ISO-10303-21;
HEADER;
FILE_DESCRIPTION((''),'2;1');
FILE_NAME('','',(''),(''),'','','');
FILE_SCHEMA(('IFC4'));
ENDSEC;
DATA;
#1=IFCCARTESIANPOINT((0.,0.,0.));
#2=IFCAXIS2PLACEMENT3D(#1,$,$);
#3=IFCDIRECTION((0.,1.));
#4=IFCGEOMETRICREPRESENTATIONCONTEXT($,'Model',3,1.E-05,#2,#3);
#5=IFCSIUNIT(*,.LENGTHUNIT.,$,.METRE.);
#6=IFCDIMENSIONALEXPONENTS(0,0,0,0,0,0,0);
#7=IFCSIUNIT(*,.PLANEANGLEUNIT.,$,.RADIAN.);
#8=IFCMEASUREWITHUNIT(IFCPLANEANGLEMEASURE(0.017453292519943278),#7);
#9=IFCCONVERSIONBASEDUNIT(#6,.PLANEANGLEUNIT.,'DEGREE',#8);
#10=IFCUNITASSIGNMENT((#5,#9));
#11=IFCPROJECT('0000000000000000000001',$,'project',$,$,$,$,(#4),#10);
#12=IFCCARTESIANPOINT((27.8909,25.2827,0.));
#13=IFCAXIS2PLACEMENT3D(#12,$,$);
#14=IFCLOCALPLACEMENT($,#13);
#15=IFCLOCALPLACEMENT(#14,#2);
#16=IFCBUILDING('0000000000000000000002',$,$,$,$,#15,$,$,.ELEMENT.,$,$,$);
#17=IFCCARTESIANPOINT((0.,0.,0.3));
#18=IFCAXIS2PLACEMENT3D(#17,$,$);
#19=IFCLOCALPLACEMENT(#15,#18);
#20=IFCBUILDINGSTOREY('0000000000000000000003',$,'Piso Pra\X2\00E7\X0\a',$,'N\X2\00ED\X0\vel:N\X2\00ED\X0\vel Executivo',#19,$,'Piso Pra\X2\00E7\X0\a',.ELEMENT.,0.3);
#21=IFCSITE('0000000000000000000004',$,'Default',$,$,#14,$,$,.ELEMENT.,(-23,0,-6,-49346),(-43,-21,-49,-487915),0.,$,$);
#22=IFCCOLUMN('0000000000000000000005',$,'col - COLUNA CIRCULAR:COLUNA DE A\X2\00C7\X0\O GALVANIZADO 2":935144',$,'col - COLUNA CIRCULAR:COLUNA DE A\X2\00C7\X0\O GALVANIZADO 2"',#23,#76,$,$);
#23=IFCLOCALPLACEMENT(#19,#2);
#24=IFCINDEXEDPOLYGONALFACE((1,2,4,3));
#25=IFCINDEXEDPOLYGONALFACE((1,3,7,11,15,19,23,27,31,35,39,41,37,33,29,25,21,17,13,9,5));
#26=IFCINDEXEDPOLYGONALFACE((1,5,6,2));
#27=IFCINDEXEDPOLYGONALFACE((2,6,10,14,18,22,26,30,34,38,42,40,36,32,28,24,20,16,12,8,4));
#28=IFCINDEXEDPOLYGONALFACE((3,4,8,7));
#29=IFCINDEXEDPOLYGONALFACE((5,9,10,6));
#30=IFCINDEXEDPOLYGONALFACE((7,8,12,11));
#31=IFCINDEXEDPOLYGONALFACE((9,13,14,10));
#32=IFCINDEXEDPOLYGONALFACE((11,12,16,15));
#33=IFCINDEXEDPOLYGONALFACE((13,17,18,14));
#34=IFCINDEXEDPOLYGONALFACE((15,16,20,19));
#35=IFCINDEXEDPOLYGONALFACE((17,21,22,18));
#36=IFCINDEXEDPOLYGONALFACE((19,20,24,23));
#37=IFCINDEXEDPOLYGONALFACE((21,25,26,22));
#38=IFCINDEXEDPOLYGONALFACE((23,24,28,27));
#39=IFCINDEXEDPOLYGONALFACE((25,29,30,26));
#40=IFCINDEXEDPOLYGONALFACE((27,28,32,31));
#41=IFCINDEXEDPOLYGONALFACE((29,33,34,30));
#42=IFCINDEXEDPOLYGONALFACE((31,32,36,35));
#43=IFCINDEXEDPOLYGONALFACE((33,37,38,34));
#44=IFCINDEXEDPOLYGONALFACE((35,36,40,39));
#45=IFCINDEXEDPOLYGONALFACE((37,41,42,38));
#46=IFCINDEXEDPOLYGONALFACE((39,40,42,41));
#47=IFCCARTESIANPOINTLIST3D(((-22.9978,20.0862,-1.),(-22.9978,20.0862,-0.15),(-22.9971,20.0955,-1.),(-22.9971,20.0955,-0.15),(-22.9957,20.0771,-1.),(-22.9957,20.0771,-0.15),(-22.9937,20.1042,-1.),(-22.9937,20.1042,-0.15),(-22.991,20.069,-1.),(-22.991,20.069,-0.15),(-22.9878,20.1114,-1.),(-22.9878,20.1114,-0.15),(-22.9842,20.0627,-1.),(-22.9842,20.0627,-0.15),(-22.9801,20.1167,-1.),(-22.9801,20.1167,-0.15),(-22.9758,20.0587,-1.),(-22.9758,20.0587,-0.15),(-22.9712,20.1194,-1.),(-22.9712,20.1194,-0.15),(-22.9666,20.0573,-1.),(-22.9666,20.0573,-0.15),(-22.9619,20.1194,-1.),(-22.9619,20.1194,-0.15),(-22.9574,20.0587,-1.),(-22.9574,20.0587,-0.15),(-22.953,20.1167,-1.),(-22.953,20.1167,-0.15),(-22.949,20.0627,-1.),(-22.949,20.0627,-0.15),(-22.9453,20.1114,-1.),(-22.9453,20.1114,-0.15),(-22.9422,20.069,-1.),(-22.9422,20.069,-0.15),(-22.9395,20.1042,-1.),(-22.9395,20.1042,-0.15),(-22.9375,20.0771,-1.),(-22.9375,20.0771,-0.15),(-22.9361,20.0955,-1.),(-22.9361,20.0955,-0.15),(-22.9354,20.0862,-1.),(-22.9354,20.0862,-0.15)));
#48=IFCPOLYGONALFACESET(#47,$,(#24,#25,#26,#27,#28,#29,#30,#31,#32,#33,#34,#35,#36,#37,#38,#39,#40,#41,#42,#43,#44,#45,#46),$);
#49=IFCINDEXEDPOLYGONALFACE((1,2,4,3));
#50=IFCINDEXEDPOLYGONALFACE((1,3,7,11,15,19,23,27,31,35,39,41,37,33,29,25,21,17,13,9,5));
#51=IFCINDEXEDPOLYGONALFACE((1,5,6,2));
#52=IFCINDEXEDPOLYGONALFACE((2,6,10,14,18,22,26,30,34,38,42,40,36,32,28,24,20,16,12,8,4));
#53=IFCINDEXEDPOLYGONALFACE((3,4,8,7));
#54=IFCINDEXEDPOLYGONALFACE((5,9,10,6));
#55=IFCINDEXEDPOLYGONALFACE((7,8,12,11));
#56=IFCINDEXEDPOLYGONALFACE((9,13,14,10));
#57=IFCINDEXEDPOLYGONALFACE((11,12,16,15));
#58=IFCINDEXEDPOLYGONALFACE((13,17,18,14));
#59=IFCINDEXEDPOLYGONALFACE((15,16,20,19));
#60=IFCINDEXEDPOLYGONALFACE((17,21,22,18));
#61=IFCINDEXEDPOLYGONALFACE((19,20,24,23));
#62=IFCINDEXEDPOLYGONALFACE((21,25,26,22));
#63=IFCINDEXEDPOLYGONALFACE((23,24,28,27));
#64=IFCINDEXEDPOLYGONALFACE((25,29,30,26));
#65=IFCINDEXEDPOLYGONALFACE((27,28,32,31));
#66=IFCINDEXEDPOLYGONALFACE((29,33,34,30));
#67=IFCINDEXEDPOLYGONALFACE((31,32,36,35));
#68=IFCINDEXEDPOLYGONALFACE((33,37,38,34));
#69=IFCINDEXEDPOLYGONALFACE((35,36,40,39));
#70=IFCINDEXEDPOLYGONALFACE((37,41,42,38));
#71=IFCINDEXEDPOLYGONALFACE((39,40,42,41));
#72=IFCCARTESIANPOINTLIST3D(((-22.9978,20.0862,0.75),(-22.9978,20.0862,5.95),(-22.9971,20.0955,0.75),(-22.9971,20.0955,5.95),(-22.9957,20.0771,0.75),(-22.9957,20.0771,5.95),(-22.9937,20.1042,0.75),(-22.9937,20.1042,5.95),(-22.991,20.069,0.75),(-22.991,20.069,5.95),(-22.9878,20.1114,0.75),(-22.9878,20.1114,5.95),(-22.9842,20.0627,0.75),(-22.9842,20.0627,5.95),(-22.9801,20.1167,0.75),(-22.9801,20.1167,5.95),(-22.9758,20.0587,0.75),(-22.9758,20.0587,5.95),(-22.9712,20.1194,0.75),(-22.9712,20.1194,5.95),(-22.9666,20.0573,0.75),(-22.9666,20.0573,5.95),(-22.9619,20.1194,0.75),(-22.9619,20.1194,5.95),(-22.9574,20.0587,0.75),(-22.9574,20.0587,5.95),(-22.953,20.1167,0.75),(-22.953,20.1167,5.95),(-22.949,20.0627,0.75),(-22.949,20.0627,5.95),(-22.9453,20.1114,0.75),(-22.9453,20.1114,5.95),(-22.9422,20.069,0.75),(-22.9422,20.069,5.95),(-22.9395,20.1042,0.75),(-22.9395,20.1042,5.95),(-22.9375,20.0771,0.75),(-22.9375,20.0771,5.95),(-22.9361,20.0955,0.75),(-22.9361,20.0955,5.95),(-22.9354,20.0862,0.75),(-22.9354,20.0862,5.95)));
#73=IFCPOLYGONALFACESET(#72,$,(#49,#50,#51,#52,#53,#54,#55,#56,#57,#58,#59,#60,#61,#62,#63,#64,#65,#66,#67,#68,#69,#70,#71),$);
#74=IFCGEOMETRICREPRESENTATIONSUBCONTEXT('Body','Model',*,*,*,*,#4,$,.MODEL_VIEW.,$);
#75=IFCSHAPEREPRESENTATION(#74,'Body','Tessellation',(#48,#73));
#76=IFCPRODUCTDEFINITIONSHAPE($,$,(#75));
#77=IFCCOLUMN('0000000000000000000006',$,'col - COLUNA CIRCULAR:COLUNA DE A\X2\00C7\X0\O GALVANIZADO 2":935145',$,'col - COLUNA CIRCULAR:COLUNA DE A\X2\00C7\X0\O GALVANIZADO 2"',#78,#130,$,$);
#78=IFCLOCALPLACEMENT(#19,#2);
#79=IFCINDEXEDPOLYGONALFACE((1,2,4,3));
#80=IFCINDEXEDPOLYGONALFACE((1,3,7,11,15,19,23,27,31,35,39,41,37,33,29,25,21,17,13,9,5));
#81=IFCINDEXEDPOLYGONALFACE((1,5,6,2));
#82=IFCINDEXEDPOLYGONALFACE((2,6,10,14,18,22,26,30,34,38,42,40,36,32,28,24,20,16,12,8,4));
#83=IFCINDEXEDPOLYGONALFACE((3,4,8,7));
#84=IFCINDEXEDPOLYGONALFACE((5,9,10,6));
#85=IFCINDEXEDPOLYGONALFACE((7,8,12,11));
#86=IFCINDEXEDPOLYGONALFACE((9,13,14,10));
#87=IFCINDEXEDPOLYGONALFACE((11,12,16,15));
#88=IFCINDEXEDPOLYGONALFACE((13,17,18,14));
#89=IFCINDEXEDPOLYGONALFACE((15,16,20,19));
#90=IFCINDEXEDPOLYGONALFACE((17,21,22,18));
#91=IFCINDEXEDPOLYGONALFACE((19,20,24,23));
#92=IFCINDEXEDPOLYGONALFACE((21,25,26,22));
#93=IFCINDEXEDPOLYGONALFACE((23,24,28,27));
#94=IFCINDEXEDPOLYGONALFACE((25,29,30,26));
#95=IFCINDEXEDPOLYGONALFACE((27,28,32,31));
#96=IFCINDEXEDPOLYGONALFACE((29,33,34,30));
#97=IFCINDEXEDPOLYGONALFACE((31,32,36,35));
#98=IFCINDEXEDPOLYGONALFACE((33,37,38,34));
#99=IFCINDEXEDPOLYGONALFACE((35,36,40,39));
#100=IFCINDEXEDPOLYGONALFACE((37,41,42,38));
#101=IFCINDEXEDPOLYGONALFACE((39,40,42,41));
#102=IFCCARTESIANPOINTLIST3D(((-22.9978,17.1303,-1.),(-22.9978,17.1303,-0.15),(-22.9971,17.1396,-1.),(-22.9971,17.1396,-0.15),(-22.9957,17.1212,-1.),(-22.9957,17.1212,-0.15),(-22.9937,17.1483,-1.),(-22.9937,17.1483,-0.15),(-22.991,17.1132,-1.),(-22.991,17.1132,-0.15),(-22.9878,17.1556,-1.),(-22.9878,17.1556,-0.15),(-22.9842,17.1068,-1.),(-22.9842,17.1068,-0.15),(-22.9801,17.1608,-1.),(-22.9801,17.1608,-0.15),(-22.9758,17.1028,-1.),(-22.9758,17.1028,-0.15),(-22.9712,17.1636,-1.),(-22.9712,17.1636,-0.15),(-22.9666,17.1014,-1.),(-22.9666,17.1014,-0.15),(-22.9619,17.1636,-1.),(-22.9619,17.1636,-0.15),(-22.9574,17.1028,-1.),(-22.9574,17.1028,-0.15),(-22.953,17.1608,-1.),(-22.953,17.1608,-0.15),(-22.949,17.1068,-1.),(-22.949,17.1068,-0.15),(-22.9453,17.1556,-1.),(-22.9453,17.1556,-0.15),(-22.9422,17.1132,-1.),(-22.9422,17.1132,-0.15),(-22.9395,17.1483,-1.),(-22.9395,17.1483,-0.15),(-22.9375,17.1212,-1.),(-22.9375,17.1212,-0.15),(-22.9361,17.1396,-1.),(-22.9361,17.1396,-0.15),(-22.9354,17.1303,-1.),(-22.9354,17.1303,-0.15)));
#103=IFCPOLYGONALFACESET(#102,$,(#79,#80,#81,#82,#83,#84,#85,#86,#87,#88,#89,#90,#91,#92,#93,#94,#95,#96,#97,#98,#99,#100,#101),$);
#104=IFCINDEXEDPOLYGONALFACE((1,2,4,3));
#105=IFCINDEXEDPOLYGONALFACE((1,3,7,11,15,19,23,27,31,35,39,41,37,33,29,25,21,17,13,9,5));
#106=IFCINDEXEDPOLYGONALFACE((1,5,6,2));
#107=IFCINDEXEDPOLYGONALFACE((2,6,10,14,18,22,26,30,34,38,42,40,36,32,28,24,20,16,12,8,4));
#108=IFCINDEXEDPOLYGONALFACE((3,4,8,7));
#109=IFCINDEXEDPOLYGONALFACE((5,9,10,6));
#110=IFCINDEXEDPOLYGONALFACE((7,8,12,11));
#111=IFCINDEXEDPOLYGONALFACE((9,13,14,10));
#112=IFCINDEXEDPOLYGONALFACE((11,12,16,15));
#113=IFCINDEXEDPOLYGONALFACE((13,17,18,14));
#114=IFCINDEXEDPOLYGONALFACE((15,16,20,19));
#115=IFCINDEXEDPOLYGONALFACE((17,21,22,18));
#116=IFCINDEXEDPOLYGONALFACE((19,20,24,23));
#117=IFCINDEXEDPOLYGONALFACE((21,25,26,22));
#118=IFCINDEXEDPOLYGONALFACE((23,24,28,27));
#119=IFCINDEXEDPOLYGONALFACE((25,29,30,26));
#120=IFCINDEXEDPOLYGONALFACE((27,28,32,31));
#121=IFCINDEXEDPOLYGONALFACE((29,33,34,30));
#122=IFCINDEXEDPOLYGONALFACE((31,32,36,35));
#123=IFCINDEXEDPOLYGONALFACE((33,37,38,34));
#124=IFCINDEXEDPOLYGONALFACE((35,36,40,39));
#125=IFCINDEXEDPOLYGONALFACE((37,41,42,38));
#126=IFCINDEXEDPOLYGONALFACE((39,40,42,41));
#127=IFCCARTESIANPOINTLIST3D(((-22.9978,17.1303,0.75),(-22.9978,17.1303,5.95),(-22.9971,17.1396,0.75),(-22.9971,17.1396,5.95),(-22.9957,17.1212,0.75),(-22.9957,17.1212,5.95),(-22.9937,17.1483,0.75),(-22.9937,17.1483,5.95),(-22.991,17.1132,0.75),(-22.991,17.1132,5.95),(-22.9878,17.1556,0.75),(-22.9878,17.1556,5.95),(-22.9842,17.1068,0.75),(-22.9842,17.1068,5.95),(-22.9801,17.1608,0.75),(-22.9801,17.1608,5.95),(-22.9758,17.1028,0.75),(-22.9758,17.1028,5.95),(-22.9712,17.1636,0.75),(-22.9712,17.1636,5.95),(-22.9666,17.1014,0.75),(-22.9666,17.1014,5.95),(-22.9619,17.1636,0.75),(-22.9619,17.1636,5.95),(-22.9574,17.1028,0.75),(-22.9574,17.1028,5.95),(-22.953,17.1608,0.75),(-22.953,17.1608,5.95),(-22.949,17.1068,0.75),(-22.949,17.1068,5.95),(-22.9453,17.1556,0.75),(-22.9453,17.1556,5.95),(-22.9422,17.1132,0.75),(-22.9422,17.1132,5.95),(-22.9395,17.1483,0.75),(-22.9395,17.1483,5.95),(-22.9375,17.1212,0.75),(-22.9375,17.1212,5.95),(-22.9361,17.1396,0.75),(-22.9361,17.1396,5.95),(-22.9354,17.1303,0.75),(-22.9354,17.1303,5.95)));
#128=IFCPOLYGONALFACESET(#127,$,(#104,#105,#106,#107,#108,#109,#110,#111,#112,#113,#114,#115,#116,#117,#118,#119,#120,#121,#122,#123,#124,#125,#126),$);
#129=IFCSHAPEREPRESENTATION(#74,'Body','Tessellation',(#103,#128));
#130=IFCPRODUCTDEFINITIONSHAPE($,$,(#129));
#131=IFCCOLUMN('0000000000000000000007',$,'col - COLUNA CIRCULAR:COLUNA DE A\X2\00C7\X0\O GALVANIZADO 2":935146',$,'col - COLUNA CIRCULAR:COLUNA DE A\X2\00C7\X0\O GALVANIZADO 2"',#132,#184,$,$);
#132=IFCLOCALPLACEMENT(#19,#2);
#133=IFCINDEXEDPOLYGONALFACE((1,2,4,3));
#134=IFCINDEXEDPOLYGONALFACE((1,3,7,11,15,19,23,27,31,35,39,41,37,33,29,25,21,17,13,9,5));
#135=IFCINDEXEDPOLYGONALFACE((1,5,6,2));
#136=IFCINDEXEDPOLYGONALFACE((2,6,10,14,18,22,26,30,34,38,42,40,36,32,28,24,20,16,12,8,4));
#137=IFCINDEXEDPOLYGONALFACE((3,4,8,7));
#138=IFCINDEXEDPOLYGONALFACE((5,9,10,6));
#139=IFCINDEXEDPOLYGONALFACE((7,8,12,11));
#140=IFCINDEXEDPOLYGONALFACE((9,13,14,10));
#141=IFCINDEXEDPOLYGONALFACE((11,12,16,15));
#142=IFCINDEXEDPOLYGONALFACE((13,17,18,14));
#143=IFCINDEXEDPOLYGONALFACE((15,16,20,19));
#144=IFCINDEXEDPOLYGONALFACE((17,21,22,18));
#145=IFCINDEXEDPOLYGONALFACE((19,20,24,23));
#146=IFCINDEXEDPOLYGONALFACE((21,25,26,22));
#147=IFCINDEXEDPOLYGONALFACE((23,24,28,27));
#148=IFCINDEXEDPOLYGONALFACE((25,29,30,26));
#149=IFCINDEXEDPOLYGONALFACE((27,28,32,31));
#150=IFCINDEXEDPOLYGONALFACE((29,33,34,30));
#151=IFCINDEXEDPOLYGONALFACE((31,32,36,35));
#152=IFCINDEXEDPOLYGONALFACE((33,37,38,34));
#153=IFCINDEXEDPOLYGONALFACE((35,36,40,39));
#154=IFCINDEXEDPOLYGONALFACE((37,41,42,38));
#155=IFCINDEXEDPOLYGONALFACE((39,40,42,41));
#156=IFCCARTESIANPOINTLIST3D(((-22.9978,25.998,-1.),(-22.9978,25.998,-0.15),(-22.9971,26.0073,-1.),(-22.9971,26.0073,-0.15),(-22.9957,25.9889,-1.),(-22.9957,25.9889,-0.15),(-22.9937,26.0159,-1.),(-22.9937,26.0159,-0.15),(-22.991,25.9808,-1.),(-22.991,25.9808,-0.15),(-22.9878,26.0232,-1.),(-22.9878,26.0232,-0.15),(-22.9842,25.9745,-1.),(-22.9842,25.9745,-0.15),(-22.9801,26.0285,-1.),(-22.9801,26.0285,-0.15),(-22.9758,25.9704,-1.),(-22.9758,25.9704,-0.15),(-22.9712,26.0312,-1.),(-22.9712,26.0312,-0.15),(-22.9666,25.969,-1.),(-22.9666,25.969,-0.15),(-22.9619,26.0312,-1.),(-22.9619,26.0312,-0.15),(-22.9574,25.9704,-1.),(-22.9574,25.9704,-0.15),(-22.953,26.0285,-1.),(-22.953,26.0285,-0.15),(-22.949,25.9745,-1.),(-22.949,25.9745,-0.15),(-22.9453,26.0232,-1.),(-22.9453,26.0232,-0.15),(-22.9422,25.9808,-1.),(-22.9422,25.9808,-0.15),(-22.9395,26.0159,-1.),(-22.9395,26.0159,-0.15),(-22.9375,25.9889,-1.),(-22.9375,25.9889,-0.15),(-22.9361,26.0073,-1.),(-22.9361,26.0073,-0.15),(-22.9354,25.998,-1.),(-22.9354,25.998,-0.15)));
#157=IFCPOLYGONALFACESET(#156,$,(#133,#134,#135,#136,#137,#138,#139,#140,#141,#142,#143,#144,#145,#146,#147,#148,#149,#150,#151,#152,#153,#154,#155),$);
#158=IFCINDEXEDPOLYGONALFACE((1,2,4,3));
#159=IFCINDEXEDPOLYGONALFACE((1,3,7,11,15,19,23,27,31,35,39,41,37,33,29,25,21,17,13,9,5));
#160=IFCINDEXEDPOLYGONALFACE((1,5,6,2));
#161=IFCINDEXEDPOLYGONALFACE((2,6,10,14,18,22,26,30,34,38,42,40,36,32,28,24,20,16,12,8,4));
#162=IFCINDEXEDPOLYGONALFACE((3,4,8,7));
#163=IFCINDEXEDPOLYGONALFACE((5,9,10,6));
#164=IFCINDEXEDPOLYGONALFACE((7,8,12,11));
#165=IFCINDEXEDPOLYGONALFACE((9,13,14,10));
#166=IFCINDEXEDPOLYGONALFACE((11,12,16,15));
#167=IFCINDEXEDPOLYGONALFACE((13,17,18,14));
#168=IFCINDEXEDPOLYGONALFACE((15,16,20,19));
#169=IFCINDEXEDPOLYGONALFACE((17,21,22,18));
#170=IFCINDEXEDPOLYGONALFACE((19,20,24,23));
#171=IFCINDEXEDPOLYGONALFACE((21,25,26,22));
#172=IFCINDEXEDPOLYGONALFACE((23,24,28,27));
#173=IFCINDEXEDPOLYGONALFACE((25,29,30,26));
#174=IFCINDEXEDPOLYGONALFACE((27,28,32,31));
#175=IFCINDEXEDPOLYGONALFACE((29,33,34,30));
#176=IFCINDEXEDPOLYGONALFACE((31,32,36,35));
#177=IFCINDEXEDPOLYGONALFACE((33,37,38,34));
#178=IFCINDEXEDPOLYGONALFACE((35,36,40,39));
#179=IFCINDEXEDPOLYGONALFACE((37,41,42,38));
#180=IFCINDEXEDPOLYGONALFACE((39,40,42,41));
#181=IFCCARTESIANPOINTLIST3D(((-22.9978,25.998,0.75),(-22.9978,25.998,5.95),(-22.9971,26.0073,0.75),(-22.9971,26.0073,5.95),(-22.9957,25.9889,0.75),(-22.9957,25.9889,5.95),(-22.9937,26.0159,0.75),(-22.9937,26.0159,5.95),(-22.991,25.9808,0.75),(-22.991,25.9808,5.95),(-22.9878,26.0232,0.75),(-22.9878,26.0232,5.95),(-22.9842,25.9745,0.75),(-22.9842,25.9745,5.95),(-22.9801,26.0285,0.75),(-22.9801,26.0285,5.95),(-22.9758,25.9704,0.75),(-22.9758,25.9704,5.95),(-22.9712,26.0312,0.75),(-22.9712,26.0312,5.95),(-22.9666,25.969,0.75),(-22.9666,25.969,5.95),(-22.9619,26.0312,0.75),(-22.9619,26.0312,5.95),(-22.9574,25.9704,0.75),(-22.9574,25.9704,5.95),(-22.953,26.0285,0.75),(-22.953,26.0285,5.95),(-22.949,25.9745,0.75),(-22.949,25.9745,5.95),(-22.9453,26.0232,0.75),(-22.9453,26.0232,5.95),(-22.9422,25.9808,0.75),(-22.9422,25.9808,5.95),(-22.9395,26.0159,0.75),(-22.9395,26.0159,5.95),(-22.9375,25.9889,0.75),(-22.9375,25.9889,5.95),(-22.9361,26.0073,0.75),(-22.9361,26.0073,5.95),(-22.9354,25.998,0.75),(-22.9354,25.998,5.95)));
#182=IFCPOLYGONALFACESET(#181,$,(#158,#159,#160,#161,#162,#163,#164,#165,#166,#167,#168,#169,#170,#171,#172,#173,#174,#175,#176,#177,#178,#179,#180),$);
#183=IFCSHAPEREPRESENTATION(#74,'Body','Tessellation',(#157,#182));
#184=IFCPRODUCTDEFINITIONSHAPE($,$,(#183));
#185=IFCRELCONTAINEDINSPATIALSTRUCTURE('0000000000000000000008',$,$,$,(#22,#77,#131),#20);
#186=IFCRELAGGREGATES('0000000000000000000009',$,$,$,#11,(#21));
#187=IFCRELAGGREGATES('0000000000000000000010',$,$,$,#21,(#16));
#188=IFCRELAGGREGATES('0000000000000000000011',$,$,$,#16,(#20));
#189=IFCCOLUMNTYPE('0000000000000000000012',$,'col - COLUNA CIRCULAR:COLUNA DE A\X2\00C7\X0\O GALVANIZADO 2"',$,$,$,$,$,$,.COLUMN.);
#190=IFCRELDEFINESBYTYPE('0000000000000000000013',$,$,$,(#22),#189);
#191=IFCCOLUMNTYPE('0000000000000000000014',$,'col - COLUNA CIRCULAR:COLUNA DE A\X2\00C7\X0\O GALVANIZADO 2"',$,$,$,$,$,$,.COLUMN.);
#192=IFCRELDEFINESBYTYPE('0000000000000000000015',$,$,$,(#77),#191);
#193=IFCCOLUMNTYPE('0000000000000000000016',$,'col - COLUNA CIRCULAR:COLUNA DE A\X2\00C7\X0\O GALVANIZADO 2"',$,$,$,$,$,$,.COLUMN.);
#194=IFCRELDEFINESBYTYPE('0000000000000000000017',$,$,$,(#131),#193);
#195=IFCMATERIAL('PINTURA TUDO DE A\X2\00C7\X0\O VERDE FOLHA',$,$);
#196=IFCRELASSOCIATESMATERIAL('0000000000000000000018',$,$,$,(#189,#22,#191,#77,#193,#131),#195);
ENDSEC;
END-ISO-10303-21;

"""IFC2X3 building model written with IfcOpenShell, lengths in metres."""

from ifc_helpers import new_model, entity, si_unit, converted_unit, direction, frame, origin, origin_2d_with_axis, place, context, subcontext, project, spatial, circle, extrude, source, transform, mapped, material, type_object, type_shapes, element, save


model = new_model("IFC2X3")

# Units and contexts
model_context = context("Model", 3, precision=1e-05, world=origin(), true_north=direction((0.0, 1.0)))
body_context = subcontext(model_context, "Body", "Model", "MODEL_VIEW")
ifc_project = project(units=[si_unit("LENGTHUNIT", "METRE"), converted_unit("PLANEANGLEUNIT", "DEGREE", entity("IfcPlaneAngleMeasure", 0.017453292519943278), si_unit("PLANEANGLEUNIT", "RADIAN"), dimensions=[0, 0, 0, 0, 0, 0, 0])], contexts=[model_context])

# Site, building, storey
site_placement = place(None, frame((27.8909, 25.2827, 0.0)))
site = spatial("IfcSite", under=ifc_project, at=site_placement, Name="Default", CompositionType="ELEMENT", RefLatitude=(-23, 0, -6, -49346), RefLongitude=(-43, -21, -49, -487915), RefElevation=0.0)
building_placement = place(site_placement, origin())
building = spatial("IfcBuilding", under=site, at=building_placement, CompositionType="ELEMENT")
storey_placement = place(building_placement, frame((0.0, 0.0, 0.3)))
storey = spatial("IfcBuildingStorey", under=building, at=storey_placement, Name="Piso Praça", ObjectType="Nível:Nível Executivo", LongName="Piso Praça", CompositionType="ELEMENT", Elevation=0.3)

# Columns
ifc_material_1 = material(Name="PINTURA TUDO DE AÇO VERDE FOLHA")
column_type_1 = type_object("IfcColumnType", Name="col - COLUNA CIRCULAR:COLUNA DE AÇO GALVANIZADO 2\"", PredefinedType="COLUMN", material=ifc_material_1)
shared_shape_1 = source(origin(), body_context, "Body", "SweptSolid", [
    extrude(circle(Radius=0.0312, at=origin_2d_with_axis()), frame((-22.9666, 20.0885, -0.7), z_axis=(0.0, 0.0, 1.0), x_axis=(0.0, -1.0, 0.0)), (0.0, 0.0, 1.0), 0.85),
    extrude(circle(Radius=0.0312, at=origin_2d_with_axis()), frame((-22.9666, 20.0885, 1.05), z_axis=(0.0, 0.0, 1.0), x_axis=(0.0, -1.0, 0.0)), (0.0, 0.0, 1.0), 5.2),
])
type_shapes(column_type_1, [shared_shape_1])
column_1_placement = place(storey_placement, frame((0.0, 0.0, -0.3)))
element("IfcColumn", 1, at=column_1_placement, inside=storey, type_object=column_type_1, material=ifc_material_1, Name="col - COLUNA CIRCULAR:COLUNA DE AÇO GALVANIZADO 2\":935144", ObjectType="col - COLUNA CIRCULAR:COLUNA DE AÇO GALVANIZADO 2\"", context=body_context, shape_type="MappedRepresentation", body=[
    mapped(shared_shape_1, transform((0.0, 0.0, 0.0), scale=1.0)),
])
column_type_2 = type_object("IfcColumnType", Name="col - COLUNA CIRCULAR:COLUNA DE AÇO GALVANIZADO 2\"", PredefinedType="COLUMN", material=ifc_material_1)
shared_shape_2 = source(origin(), body_context, "Body", "SweptSolid", [
    extrude(circle(Radius=0.0312, at=origin_2d_with_axis()), frame((-22.9666, 17.1327, -0.7), z_axis=(0.0, 0.0, 1.0), x_axis=(0.0, -1.0, 0.0)), (0.0, 0.0, 1.0), 0.85),
    extrude(circle(Radius=0.0312, at=origin_2d_with_axis()), frame((-22.9666, 17.1327, 1.05), z_axis=(0.0, 0.0, 1.0), x_axis=(0.0, -1.0, 0.0)), (0.0, 0.0, 1.0), 5.2),
])
type_shapes(column_type_2, [shared_shape_2])
column_2_placement = place(storey_placement, frame((0.0, 0.0, -0.3)))
element("IfcColumn", 2, at=column_2_placement, inside=storey, type_object=column_type_2, material=ifc_material_1, Name="col - COLUNA CIRCULAR:COLUNA DE AÇO GALVANIZADO 2\":935145", ObjectType="col - COLUNA CIRCULAR:COLUNA DE AÇO GALVANIZADO 2\"", context=body_context, shape_type="MappedRepresentation", body=[
    mapped(shared_shape_2, transform((0.0, 0.0, 0.0), scale=1.0)),
])
column_type_3 = type_object("IfcColumnType", Name="col - COLUNA CIRCULAR:COLUNA DE AÇO GALVANIZADO 2\"", PredefinedType="COLUMN", material=ifc_material_1)
shared_shape_3 = source(origin(), body_context, "Body", "SweptSolid", [
    extrude(circle(Radius=0.0312, at=origin_2d_with_axis()), frame((-22.9666, 26.0003, -0.7), z_axis=(0.0, 0.0, 1.0), x_axis=(0.0, -1.0, 0.0)), (0.0, 0.0, 1.0), 0.85),
    extrude(circle(Radius=0.0312, at=origin_2d_with_axis()), frame((-22.9666, 26.0003, 1.05), z_axis=(0.0, 0.0, 1.0), x_axis=(0.0, -1.0, 0.0)), (0.0, 0.0, 1.0), 5.2),
])
type_shapes(column_type_3, [shared_shape_3])
column_3_placement = place(storey_placement, frame((0.0, 0.0, -0.3)))
element("IfcColumn", 3, at=column_3_placement, inside=storey, type_object=column_type_3, material=ifc_material_1, Name="col - COLUNA CIRCULAR:COLUNA DE AÇO GALVANIZADO 2\":935146", ObjectType="col - COLUNA CIRCULAR:COLUNA DE AÇO GALVANIZADO 2\"", context=body_context, shape_type="MappedRepresentation", body=[
    mapped(shared_shape_3, transform((0.0, 0.0, 0.0), scale=1.0)),
])

save(model, "model.ifc")
